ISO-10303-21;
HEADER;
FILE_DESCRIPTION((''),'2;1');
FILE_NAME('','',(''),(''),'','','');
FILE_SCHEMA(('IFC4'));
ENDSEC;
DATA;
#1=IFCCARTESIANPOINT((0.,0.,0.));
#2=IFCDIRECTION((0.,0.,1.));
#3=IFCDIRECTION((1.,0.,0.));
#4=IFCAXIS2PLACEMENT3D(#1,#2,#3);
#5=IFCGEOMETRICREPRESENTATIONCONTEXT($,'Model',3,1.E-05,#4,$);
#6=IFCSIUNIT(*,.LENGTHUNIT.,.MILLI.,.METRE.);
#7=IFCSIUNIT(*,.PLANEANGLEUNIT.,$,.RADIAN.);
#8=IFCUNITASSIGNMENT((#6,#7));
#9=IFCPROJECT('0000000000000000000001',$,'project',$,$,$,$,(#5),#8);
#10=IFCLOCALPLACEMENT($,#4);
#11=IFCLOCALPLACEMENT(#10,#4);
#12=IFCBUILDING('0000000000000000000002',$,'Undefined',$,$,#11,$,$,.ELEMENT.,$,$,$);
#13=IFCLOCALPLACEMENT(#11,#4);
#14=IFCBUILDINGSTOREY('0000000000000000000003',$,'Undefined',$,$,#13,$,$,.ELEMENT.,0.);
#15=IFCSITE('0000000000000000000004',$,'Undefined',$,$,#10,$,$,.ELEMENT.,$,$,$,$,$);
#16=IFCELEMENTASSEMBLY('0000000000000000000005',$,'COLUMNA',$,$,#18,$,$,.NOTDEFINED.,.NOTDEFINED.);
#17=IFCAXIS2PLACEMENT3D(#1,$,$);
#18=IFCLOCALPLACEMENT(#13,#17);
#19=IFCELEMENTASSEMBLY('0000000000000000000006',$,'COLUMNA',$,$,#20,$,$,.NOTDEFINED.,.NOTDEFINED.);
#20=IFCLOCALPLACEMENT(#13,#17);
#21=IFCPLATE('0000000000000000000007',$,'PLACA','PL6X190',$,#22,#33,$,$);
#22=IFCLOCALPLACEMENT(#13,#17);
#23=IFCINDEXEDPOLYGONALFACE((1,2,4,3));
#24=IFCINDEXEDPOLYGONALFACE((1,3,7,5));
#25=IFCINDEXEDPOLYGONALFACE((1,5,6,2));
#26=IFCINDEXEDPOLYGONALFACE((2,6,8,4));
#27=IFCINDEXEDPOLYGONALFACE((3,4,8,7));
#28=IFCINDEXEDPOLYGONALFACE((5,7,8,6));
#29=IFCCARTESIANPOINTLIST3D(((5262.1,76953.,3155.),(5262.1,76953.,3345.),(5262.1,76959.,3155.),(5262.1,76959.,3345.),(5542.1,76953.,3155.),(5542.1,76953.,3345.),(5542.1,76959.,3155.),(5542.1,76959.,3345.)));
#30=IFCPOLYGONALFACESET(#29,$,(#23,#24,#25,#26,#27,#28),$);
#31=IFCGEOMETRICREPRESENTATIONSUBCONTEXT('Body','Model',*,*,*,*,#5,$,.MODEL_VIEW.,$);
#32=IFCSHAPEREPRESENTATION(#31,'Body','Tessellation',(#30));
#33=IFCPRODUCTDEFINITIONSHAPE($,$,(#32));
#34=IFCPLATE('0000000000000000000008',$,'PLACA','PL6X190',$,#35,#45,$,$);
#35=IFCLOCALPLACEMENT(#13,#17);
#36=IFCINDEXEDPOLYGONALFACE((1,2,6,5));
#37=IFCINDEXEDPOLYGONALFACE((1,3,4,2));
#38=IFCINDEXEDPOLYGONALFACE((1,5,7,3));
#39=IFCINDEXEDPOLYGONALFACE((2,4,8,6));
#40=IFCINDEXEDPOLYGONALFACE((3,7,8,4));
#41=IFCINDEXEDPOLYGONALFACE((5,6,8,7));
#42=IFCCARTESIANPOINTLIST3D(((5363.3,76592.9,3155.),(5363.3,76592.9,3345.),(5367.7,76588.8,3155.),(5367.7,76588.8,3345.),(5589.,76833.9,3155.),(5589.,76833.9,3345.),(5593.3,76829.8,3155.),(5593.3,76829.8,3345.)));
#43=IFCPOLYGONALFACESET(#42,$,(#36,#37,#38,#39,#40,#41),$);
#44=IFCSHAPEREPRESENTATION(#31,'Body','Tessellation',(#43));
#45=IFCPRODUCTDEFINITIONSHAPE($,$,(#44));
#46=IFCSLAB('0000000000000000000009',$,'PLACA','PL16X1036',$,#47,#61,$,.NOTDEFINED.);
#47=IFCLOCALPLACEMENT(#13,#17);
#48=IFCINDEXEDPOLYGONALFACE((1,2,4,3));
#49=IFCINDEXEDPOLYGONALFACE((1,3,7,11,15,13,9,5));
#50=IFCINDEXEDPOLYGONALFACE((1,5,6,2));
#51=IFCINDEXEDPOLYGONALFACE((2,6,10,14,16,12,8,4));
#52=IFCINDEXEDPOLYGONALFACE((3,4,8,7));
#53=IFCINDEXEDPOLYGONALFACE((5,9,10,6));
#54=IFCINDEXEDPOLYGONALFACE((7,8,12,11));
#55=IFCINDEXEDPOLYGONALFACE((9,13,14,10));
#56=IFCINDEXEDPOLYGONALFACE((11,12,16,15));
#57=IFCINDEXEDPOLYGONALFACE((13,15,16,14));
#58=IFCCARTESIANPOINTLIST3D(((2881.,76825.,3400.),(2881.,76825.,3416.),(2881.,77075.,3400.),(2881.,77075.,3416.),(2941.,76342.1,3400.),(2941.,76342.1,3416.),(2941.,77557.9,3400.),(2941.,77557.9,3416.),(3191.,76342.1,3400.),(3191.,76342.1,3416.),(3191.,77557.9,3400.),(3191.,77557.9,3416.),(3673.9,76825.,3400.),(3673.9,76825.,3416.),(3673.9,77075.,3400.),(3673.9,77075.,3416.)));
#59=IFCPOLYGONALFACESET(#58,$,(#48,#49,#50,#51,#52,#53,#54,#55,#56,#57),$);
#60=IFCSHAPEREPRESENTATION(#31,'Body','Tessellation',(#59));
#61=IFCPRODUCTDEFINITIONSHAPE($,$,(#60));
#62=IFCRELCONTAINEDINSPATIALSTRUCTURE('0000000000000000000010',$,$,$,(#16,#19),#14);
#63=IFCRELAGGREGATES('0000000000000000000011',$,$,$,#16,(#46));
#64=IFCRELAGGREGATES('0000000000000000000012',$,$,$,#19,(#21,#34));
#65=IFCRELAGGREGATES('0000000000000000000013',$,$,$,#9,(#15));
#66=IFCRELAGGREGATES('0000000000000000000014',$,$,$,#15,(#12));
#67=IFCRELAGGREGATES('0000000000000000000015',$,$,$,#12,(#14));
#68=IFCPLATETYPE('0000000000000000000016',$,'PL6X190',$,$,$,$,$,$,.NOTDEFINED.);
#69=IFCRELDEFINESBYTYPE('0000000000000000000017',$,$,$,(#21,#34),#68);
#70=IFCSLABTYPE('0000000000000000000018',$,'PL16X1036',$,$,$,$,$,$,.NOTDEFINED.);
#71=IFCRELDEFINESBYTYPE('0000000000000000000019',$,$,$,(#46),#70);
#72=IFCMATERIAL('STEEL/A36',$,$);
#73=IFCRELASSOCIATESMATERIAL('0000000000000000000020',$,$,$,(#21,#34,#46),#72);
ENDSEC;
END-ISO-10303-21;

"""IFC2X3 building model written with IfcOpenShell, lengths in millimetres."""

from ifc_helpers import new_model, si_unit, frame, origin_with_axes, place, context, subcontext, project, spatial, polyline, outline, extrude, material, type_object, element, aggregate, save


model = new_model("IFC2X3")

# Units and contexts
model_context = context("Model", 3, precision=1e-05, world=origin_with_axes())
body_context = subcontext(model_context, "Body", "Model", "MODEL_VIEW")
ifc_project = project(units=[si_unit("LENGTHUNIT", "METRE", prefix="MILLI"), si_unit("PLANEANGLEUNIT", "RADIAN")], contexts=[model_context])

# Site, building, storey
site_placement = place(None, origin_with_axes())
site = spatial("IfcSite", under=ifc_project, at=site_placement, Name="Undefined", CompositionType="ELEMENT")
building_placement = place(site_placement, origin_with_axes())
building = spatial("IfcBuilding", under=site, at=building_placement, Name="Undefined", CompositionType="ELEMENT")
storey_placement = place(building_placement, origin_with_axes())
storey = spatial("IfcBuildingStorey", under=building, at=storey_placement, Name="Undefined", CompositionType="ELEMENT", Elevation=0.0)

# Element assembly
assembly_1_placement = place(storey_placement, origin_with_axes())
assembly_1 = element("IfcElementAssembly", 1, at=assembly_1_placement, inside=storey, Name="COLUMNA", AssemblyPlace="NOTDEFINED", PredefinedType="NOTDEFINED")
ifc_material_1 = material(Name="STEEL/A36")

# Shared definitions
plate_type = type_object("IfcPlateType", Name="PL6X190", PredefinedType="NOTDEFINED")

# Element assembly, plates
assembly_2_placement = place(storey_placement, origin_with_axes())
assembly_2 = element("IfcElementAssembly", 2, at=assembly_2_placement, inside=storey, Name="COLUMNA", AssemblyPlace="NOTDEFINED", PredefinedType="NOTDEFINED")
plate_1_placement = place(assembly_2_placement, frame((5262.1, 76956.0, 3250.0), z_axis=(0.0, -1.0, 0.0), x_axis=(1.0, 0.0, 0.0)))
plate_1 = element("IfcPlate", 3, at=plate_1_placement, type_object=plate_type, material=ifc_material_1, Name="PLACA", Description="PL6X190", context=body_context, shape_type="SweptSolid", body=[
    extrude(outline(polyline([(0.0, -95.0), (0.0, 95.0), (280.0, 95.0), (280.0, -95.0), (0.0, -95.0)])), frame((0.0, 0.0, -3.0), z_axis=(0.0, 0.0, 1.0), x_axis=(1.0, 0.0, 0.0)), (0.0, 0.0, 1.0), 6.0),
])
plate_2_placement = place(assembly_2_placement, frame((5365.5, 76590.9, 3250.0), z_axis=(0.729923, -0.683529, 0.0), x_axis=(0.683529, 0.729924, 0.0)))
plate_2 = element("IfcPlate", 4, at=plate_2_placement, type_object=plate_type, material=ifc_material_1, Name="PLACA", Description="PL6X190", context=body_context, shape_type="SweptSolid", body=[
    extrude(outline(polyline([(0.0, -95.0), (0.0, 95.0), (330.1, 95.0), (330.1, -95.0), (0.0, -95.0)])), frame((0.0, 0.0, -3.0), z_axis=(0.0, 0.0, 1.0), x_axis=(1.0, 0.0, 0.0)), (0.0, 0.0, 1.0), 6.0),
])

# Slab
slab_type = type_object("IfcSlabType", Name="PL16X1036", PredefinedType="NOTDEFINED")
slab_placement = place(assembly_1_placement, frame((3191.0, 76342.1, 3408.0), z_axis=(0.0, 0.0, 1.0), x_axis=(0.707107, 0.707107, 0.0)))
slab = element("IfcSlab", 5, at=slab_placement, type_object=slab_type, material=ifc_material_1, Name="PLACA", Description="PL16X1036", PredefinedType="NOTDEFINED", context=body_context, shape_type="SweptSolid", body=[
    extrude(outline(polyline([(0.0, 0.0), (682.9, 0.0), (859.7, 176.8), (859.7, 859.7), (682.9, 1036.5), (299.0, 737.4), (122.3, 560.7), (-176.8, 176.8), (0.0, 0.0)])), frame((0.0, 0.0, -8.0), z_axis=(0.0, 0.0, 1.0), x_axis=(1.0, 0.0, 0.0)), (0.0, 0.0, 1.0), 16.0),
])

aggregate(assembly_1, [slab])
aggregate(assembly_2, [plate_1, plate_2])

save(model, "model.ifc")
